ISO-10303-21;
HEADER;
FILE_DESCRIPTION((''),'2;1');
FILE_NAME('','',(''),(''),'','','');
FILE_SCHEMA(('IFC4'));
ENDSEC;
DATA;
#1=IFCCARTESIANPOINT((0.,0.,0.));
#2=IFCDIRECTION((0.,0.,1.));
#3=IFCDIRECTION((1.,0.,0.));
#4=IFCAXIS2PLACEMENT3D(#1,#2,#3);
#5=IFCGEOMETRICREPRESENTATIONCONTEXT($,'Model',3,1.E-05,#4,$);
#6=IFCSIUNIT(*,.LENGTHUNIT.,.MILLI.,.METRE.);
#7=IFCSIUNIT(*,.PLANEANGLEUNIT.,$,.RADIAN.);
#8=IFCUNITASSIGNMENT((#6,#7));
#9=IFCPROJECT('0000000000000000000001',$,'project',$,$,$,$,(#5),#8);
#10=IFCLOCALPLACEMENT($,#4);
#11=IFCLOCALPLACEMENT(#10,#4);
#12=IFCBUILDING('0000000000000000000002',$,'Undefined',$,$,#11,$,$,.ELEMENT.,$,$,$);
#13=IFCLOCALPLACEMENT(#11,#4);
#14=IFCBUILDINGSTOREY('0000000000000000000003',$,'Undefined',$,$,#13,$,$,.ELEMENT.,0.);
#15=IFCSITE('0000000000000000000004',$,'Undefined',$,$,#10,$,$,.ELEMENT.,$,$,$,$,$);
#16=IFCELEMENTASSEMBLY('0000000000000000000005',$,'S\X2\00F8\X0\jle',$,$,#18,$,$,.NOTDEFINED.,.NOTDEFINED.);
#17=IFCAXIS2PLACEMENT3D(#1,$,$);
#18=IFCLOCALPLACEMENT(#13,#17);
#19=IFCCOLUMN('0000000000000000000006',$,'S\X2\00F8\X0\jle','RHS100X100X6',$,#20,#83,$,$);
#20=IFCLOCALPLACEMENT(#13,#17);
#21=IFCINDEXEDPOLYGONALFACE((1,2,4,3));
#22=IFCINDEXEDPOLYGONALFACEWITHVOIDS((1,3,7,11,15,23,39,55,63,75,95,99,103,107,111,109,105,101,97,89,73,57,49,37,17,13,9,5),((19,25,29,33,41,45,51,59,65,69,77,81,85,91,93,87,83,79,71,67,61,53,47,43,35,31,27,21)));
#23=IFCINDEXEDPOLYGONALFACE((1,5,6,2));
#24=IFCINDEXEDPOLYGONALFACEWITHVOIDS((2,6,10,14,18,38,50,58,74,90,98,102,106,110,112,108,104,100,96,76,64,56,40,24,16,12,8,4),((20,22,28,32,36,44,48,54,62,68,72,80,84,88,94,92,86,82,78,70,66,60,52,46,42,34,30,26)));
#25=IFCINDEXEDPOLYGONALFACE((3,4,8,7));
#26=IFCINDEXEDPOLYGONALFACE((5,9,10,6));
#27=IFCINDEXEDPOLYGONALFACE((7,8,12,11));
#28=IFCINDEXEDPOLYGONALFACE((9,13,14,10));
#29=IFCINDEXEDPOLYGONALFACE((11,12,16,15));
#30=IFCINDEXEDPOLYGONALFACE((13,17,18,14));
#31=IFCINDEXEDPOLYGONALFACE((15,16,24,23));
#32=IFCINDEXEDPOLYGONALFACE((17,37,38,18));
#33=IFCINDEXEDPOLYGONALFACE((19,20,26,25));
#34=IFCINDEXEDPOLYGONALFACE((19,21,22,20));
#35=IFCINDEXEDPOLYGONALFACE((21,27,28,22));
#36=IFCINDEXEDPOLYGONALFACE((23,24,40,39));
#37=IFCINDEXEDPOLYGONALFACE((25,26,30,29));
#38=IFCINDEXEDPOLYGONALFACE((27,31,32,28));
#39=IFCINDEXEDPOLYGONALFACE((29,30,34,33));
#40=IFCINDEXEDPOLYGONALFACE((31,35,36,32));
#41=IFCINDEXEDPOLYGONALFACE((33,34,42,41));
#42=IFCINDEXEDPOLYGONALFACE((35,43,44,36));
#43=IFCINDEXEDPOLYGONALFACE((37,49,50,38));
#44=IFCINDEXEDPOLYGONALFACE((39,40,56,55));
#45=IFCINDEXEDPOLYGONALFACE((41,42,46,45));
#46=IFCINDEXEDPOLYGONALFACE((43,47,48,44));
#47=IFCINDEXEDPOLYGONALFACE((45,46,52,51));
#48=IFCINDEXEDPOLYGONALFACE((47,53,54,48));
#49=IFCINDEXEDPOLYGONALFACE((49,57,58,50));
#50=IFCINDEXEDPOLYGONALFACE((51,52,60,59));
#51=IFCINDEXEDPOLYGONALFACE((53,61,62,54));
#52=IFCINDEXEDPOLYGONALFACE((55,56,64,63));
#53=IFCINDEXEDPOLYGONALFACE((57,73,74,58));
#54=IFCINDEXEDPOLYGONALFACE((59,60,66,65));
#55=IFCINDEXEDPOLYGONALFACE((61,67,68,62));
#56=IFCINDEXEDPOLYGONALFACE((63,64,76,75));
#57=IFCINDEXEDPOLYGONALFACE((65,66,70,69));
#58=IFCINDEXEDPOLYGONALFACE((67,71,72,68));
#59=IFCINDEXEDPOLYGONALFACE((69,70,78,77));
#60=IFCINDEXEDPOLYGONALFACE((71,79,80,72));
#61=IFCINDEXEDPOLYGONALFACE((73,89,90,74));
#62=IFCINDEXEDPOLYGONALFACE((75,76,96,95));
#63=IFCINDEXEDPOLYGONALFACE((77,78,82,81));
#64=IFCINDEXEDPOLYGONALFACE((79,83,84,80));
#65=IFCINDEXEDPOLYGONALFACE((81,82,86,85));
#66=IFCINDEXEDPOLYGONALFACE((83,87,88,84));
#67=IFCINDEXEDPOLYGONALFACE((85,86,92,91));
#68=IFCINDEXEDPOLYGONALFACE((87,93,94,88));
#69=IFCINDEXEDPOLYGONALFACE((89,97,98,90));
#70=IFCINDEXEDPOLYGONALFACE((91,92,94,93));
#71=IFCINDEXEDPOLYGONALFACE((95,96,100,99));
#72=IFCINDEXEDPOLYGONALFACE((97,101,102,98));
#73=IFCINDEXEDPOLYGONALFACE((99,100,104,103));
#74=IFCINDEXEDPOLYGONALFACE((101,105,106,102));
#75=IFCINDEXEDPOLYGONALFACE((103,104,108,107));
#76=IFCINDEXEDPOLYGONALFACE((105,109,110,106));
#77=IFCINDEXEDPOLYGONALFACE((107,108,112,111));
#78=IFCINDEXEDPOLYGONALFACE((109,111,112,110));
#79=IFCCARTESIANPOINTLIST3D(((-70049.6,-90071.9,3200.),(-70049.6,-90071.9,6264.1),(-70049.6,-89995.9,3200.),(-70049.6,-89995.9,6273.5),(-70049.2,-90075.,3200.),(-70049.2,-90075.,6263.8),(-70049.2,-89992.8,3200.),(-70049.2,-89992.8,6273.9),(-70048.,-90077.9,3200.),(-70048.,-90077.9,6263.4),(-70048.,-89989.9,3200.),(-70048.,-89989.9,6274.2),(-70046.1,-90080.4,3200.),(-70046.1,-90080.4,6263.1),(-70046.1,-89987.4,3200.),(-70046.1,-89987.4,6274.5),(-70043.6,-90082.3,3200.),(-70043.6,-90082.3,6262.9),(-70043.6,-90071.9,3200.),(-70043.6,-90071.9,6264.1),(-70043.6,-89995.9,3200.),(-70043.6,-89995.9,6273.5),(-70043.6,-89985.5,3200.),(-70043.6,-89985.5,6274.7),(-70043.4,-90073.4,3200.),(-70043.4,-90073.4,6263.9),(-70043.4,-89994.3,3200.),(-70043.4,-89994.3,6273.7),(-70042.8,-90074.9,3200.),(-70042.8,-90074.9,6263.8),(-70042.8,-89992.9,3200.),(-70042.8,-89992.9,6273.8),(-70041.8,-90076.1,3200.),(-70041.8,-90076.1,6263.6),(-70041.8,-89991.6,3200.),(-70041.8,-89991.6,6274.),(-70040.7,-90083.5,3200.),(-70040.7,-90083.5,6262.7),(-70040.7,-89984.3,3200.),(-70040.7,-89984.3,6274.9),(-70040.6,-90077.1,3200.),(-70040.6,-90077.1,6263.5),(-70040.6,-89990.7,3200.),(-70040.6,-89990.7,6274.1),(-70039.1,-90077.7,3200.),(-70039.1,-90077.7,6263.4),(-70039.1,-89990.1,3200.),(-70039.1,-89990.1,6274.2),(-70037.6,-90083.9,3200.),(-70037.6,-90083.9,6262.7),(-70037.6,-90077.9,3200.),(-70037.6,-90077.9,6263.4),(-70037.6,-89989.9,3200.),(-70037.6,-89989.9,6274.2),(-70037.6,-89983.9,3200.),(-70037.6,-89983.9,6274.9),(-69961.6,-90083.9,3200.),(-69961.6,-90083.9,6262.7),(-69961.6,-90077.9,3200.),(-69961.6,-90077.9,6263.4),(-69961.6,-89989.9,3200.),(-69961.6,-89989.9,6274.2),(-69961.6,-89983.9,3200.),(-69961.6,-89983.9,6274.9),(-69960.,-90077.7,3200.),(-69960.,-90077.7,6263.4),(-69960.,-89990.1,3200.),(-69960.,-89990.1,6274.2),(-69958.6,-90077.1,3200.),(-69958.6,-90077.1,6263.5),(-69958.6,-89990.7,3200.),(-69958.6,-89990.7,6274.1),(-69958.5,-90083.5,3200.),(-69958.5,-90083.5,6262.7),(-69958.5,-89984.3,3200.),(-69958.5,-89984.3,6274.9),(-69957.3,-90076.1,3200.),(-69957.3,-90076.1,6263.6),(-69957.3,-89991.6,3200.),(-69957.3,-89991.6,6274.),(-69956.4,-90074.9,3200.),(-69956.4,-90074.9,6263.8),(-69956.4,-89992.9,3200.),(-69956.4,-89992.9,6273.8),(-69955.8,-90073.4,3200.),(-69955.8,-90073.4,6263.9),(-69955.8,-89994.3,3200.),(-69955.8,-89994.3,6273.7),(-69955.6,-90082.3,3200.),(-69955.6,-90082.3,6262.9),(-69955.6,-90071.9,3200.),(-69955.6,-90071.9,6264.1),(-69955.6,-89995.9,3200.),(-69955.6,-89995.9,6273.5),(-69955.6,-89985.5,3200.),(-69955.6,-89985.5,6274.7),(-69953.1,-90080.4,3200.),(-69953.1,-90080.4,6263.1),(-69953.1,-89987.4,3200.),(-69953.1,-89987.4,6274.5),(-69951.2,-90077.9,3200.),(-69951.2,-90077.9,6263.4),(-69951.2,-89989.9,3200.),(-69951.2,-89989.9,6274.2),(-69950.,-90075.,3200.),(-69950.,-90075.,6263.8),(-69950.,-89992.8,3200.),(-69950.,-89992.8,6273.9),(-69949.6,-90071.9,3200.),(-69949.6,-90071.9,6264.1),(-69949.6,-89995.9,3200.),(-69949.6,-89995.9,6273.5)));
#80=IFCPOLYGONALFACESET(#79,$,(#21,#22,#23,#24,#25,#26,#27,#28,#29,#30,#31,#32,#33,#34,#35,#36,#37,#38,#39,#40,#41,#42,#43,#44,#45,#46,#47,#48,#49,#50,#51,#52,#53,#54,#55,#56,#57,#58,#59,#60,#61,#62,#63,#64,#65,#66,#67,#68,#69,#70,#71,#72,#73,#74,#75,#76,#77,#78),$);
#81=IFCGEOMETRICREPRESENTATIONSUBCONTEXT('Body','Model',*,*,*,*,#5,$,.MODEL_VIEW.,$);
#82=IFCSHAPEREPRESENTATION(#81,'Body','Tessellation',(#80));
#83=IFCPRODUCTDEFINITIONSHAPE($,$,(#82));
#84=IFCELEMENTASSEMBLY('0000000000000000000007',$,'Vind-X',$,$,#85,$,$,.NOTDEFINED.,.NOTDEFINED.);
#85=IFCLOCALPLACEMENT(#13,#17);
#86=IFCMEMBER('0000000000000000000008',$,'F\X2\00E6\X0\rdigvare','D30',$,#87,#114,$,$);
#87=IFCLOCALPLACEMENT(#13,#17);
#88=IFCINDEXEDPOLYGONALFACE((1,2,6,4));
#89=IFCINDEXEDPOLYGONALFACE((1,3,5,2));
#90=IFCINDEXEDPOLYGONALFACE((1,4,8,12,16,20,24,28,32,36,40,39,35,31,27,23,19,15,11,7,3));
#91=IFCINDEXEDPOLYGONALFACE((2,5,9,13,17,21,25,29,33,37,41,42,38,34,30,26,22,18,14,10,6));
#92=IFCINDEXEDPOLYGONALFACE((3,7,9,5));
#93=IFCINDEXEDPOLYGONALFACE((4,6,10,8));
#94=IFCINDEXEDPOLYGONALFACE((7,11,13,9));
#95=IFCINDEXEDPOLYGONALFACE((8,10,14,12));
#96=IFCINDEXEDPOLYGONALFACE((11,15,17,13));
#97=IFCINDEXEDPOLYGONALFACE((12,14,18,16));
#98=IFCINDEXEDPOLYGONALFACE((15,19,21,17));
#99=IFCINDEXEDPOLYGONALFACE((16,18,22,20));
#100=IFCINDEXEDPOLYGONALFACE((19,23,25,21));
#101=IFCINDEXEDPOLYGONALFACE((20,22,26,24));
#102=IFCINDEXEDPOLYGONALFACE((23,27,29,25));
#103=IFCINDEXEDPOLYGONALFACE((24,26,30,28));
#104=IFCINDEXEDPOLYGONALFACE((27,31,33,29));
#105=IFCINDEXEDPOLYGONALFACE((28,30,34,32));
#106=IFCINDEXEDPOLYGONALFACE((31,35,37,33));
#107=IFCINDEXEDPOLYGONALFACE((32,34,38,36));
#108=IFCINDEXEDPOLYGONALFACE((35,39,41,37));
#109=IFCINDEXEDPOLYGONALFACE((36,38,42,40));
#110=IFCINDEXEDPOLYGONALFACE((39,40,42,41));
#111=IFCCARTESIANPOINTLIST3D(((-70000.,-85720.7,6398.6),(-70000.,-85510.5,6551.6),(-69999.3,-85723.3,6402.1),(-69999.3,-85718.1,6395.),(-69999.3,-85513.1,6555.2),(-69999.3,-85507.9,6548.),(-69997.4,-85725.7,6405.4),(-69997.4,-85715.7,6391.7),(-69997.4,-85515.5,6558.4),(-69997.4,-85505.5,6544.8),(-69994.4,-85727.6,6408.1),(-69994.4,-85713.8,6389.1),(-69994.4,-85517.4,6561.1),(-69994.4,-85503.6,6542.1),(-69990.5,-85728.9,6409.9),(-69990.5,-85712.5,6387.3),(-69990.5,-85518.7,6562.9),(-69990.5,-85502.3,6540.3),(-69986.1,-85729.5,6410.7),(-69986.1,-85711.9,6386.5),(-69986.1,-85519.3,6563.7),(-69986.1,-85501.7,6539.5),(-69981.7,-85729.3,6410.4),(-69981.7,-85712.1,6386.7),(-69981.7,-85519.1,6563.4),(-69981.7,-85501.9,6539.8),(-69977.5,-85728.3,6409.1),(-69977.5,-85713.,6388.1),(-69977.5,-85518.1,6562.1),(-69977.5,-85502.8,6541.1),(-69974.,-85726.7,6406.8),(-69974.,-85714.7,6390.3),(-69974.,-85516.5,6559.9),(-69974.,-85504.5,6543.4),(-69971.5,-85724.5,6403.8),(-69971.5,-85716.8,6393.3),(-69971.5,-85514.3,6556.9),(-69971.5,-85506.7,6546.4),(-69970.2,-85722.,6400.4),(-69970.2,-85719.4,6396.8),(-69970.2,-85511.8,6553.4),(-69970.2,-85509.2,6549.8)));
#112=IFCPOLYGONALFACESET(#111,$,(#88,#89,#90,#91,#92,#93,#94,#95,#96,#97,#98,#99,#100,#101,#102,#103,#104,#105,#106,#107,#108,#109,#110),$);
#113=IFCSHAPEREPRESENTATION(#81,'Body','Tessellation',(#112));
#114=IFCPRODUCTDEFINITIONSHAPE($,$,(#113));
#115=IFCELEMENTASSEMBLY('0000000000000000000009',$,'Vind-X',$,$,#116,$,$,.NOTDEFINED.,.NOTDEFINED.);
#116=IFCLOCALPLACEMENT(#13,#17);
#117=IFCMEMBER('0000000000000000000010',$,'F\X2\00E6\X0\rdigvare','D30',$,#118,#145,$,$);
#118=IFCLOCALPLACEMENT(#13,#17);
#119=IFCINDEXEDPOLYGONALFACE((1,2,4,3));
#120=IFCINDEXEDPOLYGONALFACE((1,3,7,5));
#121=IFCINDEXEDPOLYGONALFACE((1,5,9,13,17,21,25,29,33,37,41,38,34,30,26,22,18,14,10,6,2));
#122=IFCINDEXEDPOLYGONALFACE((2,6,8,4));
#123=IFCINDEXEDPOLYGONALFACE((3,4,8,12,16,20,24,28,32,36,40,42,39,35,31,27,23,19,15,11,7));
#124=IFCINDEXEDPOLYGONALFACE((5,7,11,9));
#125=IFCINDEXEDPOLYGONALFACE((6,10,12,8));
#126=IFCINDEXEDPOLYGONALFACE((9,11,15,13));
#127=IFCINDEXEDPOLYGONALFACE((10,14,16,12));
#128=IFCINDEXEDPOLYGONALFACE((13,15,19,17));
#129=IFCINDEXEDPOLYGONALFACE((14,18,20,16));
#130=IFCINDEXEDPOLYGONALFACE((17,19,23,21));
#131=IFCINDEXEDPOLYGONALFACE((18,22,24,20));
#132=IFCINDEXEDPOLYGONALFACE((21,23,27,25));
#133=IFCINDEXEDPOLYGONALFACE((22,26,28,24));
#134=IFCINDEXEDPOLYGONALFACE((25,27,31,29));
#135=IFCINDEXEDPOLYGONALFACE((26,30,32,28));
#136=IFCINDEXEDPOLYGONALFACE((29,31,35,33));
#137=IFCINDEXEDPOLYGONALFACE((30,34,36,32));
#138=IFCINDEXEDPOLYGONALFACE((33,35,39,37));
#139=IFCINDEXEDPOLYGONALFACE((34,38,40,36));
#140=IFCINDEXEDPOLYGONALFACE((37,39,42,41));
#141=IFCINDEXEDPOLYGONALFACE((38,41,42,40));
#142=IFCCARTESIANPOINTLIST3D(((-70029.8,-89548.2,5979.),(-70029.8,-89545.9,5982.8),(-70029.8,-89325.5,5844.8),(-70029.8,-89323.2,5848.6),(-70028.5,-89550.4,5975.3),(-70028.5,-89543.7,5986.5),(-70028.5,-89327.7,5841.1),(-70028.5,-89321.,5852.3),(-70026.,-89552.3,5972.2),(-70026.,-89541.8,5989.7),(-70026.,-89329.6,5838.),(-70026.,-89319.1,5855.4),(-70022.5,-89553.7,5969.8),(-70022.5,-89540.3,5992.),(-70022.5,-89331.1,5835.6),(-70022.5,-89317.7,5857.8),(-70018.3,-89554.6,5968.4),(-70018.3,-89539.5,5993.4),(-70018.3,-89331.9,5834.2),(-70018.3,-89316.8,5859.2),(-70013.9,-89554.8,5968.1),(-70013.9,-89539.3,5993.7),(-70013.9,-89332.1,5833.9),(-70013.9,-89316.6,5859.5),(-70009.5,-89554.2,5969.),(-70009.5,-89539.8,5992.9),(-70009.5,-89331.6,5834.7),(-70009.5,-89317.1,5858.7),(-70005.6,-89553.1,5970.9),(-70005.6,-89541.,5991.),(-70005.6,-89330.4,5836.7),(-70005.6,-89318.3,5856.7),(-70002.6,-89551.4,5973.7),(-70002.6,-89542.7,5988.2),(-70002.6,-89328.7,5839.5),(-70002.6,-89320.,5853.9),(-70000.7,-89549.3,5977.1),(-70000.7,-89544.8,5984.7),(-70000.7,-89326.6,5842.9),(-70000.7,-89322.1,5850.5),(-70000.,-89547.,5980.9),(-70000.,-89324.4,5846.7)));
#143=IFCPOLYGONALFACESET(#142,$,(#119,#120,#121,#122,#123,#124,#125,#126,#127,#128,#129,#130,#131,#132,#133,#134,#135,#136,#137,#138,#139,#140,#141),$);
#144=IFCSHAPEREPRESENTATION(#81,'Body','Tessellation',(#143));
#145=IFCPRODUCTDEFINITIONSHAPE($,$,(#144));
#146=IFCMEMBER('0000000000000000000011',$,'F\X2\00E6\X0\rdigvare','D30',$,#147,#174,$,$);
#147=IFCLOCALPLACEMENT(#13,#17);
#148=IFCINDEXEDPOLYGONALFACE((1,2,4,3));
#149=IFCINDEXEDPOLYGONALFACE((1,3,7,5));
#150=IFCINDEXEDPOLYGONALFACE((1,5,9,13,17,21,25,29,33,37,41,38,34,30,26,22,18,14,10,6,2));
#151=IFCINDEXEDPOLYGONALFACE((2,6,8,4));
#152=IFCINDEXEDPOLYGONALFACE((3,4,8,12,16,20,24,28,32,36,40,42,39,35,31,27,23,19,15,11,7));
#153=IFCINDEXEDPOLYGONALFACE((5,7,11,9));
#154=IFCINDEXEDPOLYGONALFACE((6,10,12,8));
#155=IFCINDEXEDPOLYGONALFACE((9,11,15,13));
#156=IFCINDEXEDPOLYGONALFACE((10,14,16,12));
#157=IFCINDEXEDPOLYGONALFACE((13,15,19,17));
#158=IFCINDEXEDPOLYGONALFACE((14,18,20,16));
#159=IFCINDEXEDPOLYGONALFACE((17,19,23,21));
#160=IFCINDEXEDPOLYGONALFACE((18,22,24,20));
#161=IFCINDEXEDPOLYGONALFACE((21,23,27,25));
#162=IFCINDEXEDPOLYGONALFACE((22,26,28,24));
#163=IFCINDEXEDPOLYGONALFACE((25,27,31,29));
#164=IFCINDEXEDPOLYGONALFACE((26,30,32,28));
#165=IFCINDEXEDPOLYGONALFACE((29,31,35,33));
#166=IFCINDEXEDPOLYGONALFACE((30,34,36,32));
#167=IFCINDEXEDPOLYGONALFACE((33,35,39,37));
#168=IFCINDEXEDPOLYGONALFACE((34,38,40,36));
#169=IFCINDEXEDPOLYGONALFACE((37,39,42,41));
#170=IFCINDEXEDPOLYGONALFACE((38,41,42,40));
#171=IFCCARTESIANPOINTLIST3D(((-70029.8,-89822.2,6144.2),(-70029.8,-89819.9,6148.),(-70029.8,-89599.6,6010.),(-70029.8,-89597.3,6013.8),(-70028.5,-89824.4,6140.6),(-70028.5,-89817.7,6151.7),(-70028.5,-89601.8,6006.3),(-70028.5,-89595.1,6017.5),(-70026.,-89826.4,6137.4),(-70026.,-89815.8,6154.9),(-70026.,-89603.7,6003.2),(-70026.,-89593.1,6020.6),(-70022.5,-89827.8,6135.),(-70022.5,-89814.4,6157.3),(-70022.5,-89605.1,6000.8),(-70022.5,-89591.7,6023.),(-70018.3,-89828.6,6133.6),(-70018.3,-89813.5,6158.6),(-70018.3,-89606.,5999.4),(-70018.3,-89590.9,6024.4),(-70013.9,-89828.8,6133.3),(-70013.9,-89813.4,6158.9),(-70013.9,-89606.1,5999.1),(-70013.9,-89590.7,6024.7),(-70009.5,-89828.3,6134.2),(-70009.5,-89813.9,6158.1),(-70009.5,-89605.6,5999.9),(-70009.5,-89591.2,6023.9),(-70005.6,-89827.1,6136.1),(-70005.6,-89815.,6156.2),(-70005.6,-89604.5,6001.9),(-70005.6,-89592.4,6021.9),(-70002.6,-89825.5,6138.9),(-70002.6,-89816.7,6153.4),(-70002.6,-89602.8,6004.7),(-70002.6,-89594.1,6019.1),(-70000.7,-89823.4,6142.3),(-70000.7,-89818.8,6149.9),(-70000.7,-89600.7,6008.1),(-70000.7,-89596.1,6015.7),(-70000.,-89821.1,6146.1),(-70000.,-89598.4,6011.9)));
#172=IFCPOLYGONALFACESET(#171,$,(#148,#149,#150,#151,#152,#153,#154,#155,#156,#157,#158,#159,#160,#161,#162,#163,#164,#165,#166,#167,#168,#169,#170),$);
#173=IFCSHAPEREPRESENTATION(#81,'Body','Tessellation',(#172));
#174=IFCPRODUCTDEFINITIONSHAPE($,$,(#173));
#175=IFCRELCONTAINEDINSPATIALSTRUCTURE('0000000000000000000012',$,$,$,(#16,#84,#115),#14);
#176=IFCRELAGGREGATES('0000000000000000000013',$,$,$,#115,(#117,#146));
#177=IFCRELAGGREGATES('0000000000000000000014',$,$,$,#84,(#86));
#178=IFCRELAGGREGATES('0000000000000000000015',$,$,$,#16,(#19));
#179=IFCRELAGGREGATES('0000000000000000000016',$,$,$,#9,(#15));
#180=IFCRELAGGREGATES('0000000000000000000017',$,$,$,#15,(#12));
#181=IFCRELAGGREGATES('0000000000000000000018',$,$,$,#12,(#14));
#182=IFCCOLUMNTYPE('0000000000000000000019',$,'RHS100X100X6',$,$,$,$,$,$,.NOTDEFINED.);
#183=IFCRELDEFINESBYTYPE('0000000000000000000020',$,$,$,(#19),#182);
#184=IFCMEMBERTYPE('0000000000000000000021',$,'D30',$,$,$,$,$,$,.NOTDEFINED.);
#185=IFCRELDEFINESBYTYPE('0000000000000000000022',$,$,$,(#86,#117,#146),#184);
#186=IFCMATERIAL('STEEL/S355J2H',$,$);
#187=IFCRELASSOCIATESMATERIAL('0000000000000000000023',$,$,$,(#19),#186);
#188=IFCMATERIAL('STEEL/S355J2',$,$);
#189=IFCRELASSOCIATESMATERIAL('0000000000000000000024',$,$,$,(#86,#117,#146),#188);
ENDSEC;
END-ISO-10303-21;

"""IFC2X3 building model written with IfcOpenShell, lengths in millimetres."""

from ifc_helpers import new_model, si_unit, frame, origin_with_axes, origin_2d_with_axis, place, context, subcontext, project, spatial, hollow_rectangle, circle, extrude, clip, halfspace, material, type_object, element, aggregate, save


model = new_model("IFC2X3")

# Units and contexts
model_context = context("Model", 3, precision=1e-05, world=origin_with_axes())
body_context = subcontext(model_context, "Body", "Model", "MODEL_VIEW")
ifc_project = project(units=[si_unit("LENGTHUNIT", "METRE", prefix="MILLI"), si_unit("PLANEANGLEUNIT", "RADIAN")], contexts=[model_context])

# Site, building, storey
site_placement = place(None, origin_with_axes())
site = spatial("IfcSite", under=ifc_project, at=site_placement, Name="Undefined", CompositionType="ELEMENT")
building_placement = place(site_placement, origin_with_axes())
building = spatial("IfcBuilding", under=site, at=building_placement, Name="Undefined", CompositionType="ELEMENT")
storey_placement = place(building_placement, origin_with_axes())
storey = spatial("IfcBuildingStorey", under=building, at=storey_placement, Name="Undefined", CompositionType="ELEMENT", Elevation=0.0)

# Element assembly, column
assembly_1_placement = place(storey_placement, origin_with_axes())
assembly_1 = element("IfcElementAssembly", 1, at=assembly_1_placement, inside=storey, Name="Søjle", AssemblyPlace="NOTDEFINED", PredefinedType="NOTDEFINED")
ifc_material_1 = material(Name="STEEL/S355J2H")
column_type = type_object("IfcColumnType", Name="RHS100X100X6", PredefinedType="NOTDEFINED")
column_placement = place(assembly_1_placement, frame((-69999.6, -90033.9, 3200.0), z_axis=(0.0, 0.0, 1.0), x_axis=(0.0, -1.0, 0.0)))
column = element("IfcColumn", 2, at=column_placement, type_object=column_type, material=ifc_material_1, Name="Søjle", Description="RHS100X100X6", context=body_context, shape_type="Clipping", body=[
    clip(extrude(hollow_rectangle(XDim=100.0, YDim=100.0, WallThickness=6.0, InnerFilletRadius=6.0, OuterFilletRadius=12.0, at=origin_2d_with_axis()), frame((0.0, 0.0, 3082.8), z_axis=(0.0, 0.0, -1.0), x_axis=(0.0, 1.0, 0.0)), (0.0, 0.0, 1.0), 3082.8), halfspace(frame((50.0, 0.0, 3062.7), z_axis=(-0.121869, 0.0, -0.992546), x_axis=(0.0, 1.0, 0.0)), True)),
])

# Element assembly, member
assembly_2_placement = place(storey_placement, origin_with_axes())
assembly_2 = element("IfcElementAssembly", 3, at=assembly_2_placement, inside=storey, Name="Vind-X", AssemblyPlace="NOTDEFINED", PredefinedType="NOTDEFINED")
ifc_material_2 = material(Name="STEEL/S355J2")
member_type_1 = type_object("IfcMemberType", Name="D30", PredefinedType="NOTDEFINED")
member_1_placement = place(assembly_2_placement, frame((-69985.0, -85510.5, 6551.6), z_axis=(0.0, -0.588615, 0.808414), x_axis=(0.0, -0.808414, -0.588615)))
member_1 = element("IfcMember", 4, at=member_1_placement, type_object=member_type_1, material=ifc_material_2, Name="Færdigvare", Description="D30", context=body_context, shape_type="SweptSolid", body=[
    extrude(circle(Radius=15.0, at=origin_2d_with_axis()), frame((260.0, 0.0, 0.0), z_axis=(-1.0, 0.0, 0.0), x_axis=(0.0, -1.0, 0.0)), (0.0, 0.0, 1.0), 260.0),
])

# Element assembly, members
assembly_3_placement = place(storey_placement, origin_with_axes())
assembly_3 = element("IfcElementAssembly", 5, at=assembly_3_placement, inside=storey, Name="Vind-X", AssemblyPlace="NOTDEFINED", PredefinedType="NOTDEFINED")
member_2_placement = place(assembly_3_placement, frame((-70015.0, -89547.0, 5980.9), z_axis=(0.0, 0.516246, 0.85644), x_axis=(0.0, 0.85644, -0.516246)))
member_2 = element("IfcMember", 6, at=member_2_placement, type_object=member_type_1, material=ifc_material_2, Name="Færdigvare", Description="D30", context=body_context, shape_type="SweptSolid", body=[
    extrude(circle(Radius=15.0, at=origin_2d_with_axis()), frame((260.0, 0.0, 0.0), z_axis=(-1.0, 0.0, 0.0), x_axis=(0.0, -1.0, 0.0)), (0.0, 0.0, 1.0), 260.0),
])
member_3_placement = place(assembly_3_placement, frame((-70015.0, -89821.1, 6146.1), z_axis=(0.0, 0.516247, 0.85644), x_axis=(0.0, 0.85644, -0.516247)))
member_3 = element("IfcMember", 7, at=member_3_placement, type_object=member_type_1, material=ifc_material_2, Name="Færdigvare", Description="D30", context=body_context, shape_type="SweptSolid", body=[
    extrude(circle(Radius=15.0, at=origin_2d_with_axis()), frame((260.0, 0.0, 0.0), z_axis=(-1.0, 0.0, 0.0), x_axis=(0.0, -1.0, 0.0)), (0.0, 0.0, 1.0), 260.0),
])

aggregate(assembly_3, [member_2, member_3])
aggregate(assembly_2, [member_1])
aggregate(assembly_1, [column])

save(model, "model.ifc")
